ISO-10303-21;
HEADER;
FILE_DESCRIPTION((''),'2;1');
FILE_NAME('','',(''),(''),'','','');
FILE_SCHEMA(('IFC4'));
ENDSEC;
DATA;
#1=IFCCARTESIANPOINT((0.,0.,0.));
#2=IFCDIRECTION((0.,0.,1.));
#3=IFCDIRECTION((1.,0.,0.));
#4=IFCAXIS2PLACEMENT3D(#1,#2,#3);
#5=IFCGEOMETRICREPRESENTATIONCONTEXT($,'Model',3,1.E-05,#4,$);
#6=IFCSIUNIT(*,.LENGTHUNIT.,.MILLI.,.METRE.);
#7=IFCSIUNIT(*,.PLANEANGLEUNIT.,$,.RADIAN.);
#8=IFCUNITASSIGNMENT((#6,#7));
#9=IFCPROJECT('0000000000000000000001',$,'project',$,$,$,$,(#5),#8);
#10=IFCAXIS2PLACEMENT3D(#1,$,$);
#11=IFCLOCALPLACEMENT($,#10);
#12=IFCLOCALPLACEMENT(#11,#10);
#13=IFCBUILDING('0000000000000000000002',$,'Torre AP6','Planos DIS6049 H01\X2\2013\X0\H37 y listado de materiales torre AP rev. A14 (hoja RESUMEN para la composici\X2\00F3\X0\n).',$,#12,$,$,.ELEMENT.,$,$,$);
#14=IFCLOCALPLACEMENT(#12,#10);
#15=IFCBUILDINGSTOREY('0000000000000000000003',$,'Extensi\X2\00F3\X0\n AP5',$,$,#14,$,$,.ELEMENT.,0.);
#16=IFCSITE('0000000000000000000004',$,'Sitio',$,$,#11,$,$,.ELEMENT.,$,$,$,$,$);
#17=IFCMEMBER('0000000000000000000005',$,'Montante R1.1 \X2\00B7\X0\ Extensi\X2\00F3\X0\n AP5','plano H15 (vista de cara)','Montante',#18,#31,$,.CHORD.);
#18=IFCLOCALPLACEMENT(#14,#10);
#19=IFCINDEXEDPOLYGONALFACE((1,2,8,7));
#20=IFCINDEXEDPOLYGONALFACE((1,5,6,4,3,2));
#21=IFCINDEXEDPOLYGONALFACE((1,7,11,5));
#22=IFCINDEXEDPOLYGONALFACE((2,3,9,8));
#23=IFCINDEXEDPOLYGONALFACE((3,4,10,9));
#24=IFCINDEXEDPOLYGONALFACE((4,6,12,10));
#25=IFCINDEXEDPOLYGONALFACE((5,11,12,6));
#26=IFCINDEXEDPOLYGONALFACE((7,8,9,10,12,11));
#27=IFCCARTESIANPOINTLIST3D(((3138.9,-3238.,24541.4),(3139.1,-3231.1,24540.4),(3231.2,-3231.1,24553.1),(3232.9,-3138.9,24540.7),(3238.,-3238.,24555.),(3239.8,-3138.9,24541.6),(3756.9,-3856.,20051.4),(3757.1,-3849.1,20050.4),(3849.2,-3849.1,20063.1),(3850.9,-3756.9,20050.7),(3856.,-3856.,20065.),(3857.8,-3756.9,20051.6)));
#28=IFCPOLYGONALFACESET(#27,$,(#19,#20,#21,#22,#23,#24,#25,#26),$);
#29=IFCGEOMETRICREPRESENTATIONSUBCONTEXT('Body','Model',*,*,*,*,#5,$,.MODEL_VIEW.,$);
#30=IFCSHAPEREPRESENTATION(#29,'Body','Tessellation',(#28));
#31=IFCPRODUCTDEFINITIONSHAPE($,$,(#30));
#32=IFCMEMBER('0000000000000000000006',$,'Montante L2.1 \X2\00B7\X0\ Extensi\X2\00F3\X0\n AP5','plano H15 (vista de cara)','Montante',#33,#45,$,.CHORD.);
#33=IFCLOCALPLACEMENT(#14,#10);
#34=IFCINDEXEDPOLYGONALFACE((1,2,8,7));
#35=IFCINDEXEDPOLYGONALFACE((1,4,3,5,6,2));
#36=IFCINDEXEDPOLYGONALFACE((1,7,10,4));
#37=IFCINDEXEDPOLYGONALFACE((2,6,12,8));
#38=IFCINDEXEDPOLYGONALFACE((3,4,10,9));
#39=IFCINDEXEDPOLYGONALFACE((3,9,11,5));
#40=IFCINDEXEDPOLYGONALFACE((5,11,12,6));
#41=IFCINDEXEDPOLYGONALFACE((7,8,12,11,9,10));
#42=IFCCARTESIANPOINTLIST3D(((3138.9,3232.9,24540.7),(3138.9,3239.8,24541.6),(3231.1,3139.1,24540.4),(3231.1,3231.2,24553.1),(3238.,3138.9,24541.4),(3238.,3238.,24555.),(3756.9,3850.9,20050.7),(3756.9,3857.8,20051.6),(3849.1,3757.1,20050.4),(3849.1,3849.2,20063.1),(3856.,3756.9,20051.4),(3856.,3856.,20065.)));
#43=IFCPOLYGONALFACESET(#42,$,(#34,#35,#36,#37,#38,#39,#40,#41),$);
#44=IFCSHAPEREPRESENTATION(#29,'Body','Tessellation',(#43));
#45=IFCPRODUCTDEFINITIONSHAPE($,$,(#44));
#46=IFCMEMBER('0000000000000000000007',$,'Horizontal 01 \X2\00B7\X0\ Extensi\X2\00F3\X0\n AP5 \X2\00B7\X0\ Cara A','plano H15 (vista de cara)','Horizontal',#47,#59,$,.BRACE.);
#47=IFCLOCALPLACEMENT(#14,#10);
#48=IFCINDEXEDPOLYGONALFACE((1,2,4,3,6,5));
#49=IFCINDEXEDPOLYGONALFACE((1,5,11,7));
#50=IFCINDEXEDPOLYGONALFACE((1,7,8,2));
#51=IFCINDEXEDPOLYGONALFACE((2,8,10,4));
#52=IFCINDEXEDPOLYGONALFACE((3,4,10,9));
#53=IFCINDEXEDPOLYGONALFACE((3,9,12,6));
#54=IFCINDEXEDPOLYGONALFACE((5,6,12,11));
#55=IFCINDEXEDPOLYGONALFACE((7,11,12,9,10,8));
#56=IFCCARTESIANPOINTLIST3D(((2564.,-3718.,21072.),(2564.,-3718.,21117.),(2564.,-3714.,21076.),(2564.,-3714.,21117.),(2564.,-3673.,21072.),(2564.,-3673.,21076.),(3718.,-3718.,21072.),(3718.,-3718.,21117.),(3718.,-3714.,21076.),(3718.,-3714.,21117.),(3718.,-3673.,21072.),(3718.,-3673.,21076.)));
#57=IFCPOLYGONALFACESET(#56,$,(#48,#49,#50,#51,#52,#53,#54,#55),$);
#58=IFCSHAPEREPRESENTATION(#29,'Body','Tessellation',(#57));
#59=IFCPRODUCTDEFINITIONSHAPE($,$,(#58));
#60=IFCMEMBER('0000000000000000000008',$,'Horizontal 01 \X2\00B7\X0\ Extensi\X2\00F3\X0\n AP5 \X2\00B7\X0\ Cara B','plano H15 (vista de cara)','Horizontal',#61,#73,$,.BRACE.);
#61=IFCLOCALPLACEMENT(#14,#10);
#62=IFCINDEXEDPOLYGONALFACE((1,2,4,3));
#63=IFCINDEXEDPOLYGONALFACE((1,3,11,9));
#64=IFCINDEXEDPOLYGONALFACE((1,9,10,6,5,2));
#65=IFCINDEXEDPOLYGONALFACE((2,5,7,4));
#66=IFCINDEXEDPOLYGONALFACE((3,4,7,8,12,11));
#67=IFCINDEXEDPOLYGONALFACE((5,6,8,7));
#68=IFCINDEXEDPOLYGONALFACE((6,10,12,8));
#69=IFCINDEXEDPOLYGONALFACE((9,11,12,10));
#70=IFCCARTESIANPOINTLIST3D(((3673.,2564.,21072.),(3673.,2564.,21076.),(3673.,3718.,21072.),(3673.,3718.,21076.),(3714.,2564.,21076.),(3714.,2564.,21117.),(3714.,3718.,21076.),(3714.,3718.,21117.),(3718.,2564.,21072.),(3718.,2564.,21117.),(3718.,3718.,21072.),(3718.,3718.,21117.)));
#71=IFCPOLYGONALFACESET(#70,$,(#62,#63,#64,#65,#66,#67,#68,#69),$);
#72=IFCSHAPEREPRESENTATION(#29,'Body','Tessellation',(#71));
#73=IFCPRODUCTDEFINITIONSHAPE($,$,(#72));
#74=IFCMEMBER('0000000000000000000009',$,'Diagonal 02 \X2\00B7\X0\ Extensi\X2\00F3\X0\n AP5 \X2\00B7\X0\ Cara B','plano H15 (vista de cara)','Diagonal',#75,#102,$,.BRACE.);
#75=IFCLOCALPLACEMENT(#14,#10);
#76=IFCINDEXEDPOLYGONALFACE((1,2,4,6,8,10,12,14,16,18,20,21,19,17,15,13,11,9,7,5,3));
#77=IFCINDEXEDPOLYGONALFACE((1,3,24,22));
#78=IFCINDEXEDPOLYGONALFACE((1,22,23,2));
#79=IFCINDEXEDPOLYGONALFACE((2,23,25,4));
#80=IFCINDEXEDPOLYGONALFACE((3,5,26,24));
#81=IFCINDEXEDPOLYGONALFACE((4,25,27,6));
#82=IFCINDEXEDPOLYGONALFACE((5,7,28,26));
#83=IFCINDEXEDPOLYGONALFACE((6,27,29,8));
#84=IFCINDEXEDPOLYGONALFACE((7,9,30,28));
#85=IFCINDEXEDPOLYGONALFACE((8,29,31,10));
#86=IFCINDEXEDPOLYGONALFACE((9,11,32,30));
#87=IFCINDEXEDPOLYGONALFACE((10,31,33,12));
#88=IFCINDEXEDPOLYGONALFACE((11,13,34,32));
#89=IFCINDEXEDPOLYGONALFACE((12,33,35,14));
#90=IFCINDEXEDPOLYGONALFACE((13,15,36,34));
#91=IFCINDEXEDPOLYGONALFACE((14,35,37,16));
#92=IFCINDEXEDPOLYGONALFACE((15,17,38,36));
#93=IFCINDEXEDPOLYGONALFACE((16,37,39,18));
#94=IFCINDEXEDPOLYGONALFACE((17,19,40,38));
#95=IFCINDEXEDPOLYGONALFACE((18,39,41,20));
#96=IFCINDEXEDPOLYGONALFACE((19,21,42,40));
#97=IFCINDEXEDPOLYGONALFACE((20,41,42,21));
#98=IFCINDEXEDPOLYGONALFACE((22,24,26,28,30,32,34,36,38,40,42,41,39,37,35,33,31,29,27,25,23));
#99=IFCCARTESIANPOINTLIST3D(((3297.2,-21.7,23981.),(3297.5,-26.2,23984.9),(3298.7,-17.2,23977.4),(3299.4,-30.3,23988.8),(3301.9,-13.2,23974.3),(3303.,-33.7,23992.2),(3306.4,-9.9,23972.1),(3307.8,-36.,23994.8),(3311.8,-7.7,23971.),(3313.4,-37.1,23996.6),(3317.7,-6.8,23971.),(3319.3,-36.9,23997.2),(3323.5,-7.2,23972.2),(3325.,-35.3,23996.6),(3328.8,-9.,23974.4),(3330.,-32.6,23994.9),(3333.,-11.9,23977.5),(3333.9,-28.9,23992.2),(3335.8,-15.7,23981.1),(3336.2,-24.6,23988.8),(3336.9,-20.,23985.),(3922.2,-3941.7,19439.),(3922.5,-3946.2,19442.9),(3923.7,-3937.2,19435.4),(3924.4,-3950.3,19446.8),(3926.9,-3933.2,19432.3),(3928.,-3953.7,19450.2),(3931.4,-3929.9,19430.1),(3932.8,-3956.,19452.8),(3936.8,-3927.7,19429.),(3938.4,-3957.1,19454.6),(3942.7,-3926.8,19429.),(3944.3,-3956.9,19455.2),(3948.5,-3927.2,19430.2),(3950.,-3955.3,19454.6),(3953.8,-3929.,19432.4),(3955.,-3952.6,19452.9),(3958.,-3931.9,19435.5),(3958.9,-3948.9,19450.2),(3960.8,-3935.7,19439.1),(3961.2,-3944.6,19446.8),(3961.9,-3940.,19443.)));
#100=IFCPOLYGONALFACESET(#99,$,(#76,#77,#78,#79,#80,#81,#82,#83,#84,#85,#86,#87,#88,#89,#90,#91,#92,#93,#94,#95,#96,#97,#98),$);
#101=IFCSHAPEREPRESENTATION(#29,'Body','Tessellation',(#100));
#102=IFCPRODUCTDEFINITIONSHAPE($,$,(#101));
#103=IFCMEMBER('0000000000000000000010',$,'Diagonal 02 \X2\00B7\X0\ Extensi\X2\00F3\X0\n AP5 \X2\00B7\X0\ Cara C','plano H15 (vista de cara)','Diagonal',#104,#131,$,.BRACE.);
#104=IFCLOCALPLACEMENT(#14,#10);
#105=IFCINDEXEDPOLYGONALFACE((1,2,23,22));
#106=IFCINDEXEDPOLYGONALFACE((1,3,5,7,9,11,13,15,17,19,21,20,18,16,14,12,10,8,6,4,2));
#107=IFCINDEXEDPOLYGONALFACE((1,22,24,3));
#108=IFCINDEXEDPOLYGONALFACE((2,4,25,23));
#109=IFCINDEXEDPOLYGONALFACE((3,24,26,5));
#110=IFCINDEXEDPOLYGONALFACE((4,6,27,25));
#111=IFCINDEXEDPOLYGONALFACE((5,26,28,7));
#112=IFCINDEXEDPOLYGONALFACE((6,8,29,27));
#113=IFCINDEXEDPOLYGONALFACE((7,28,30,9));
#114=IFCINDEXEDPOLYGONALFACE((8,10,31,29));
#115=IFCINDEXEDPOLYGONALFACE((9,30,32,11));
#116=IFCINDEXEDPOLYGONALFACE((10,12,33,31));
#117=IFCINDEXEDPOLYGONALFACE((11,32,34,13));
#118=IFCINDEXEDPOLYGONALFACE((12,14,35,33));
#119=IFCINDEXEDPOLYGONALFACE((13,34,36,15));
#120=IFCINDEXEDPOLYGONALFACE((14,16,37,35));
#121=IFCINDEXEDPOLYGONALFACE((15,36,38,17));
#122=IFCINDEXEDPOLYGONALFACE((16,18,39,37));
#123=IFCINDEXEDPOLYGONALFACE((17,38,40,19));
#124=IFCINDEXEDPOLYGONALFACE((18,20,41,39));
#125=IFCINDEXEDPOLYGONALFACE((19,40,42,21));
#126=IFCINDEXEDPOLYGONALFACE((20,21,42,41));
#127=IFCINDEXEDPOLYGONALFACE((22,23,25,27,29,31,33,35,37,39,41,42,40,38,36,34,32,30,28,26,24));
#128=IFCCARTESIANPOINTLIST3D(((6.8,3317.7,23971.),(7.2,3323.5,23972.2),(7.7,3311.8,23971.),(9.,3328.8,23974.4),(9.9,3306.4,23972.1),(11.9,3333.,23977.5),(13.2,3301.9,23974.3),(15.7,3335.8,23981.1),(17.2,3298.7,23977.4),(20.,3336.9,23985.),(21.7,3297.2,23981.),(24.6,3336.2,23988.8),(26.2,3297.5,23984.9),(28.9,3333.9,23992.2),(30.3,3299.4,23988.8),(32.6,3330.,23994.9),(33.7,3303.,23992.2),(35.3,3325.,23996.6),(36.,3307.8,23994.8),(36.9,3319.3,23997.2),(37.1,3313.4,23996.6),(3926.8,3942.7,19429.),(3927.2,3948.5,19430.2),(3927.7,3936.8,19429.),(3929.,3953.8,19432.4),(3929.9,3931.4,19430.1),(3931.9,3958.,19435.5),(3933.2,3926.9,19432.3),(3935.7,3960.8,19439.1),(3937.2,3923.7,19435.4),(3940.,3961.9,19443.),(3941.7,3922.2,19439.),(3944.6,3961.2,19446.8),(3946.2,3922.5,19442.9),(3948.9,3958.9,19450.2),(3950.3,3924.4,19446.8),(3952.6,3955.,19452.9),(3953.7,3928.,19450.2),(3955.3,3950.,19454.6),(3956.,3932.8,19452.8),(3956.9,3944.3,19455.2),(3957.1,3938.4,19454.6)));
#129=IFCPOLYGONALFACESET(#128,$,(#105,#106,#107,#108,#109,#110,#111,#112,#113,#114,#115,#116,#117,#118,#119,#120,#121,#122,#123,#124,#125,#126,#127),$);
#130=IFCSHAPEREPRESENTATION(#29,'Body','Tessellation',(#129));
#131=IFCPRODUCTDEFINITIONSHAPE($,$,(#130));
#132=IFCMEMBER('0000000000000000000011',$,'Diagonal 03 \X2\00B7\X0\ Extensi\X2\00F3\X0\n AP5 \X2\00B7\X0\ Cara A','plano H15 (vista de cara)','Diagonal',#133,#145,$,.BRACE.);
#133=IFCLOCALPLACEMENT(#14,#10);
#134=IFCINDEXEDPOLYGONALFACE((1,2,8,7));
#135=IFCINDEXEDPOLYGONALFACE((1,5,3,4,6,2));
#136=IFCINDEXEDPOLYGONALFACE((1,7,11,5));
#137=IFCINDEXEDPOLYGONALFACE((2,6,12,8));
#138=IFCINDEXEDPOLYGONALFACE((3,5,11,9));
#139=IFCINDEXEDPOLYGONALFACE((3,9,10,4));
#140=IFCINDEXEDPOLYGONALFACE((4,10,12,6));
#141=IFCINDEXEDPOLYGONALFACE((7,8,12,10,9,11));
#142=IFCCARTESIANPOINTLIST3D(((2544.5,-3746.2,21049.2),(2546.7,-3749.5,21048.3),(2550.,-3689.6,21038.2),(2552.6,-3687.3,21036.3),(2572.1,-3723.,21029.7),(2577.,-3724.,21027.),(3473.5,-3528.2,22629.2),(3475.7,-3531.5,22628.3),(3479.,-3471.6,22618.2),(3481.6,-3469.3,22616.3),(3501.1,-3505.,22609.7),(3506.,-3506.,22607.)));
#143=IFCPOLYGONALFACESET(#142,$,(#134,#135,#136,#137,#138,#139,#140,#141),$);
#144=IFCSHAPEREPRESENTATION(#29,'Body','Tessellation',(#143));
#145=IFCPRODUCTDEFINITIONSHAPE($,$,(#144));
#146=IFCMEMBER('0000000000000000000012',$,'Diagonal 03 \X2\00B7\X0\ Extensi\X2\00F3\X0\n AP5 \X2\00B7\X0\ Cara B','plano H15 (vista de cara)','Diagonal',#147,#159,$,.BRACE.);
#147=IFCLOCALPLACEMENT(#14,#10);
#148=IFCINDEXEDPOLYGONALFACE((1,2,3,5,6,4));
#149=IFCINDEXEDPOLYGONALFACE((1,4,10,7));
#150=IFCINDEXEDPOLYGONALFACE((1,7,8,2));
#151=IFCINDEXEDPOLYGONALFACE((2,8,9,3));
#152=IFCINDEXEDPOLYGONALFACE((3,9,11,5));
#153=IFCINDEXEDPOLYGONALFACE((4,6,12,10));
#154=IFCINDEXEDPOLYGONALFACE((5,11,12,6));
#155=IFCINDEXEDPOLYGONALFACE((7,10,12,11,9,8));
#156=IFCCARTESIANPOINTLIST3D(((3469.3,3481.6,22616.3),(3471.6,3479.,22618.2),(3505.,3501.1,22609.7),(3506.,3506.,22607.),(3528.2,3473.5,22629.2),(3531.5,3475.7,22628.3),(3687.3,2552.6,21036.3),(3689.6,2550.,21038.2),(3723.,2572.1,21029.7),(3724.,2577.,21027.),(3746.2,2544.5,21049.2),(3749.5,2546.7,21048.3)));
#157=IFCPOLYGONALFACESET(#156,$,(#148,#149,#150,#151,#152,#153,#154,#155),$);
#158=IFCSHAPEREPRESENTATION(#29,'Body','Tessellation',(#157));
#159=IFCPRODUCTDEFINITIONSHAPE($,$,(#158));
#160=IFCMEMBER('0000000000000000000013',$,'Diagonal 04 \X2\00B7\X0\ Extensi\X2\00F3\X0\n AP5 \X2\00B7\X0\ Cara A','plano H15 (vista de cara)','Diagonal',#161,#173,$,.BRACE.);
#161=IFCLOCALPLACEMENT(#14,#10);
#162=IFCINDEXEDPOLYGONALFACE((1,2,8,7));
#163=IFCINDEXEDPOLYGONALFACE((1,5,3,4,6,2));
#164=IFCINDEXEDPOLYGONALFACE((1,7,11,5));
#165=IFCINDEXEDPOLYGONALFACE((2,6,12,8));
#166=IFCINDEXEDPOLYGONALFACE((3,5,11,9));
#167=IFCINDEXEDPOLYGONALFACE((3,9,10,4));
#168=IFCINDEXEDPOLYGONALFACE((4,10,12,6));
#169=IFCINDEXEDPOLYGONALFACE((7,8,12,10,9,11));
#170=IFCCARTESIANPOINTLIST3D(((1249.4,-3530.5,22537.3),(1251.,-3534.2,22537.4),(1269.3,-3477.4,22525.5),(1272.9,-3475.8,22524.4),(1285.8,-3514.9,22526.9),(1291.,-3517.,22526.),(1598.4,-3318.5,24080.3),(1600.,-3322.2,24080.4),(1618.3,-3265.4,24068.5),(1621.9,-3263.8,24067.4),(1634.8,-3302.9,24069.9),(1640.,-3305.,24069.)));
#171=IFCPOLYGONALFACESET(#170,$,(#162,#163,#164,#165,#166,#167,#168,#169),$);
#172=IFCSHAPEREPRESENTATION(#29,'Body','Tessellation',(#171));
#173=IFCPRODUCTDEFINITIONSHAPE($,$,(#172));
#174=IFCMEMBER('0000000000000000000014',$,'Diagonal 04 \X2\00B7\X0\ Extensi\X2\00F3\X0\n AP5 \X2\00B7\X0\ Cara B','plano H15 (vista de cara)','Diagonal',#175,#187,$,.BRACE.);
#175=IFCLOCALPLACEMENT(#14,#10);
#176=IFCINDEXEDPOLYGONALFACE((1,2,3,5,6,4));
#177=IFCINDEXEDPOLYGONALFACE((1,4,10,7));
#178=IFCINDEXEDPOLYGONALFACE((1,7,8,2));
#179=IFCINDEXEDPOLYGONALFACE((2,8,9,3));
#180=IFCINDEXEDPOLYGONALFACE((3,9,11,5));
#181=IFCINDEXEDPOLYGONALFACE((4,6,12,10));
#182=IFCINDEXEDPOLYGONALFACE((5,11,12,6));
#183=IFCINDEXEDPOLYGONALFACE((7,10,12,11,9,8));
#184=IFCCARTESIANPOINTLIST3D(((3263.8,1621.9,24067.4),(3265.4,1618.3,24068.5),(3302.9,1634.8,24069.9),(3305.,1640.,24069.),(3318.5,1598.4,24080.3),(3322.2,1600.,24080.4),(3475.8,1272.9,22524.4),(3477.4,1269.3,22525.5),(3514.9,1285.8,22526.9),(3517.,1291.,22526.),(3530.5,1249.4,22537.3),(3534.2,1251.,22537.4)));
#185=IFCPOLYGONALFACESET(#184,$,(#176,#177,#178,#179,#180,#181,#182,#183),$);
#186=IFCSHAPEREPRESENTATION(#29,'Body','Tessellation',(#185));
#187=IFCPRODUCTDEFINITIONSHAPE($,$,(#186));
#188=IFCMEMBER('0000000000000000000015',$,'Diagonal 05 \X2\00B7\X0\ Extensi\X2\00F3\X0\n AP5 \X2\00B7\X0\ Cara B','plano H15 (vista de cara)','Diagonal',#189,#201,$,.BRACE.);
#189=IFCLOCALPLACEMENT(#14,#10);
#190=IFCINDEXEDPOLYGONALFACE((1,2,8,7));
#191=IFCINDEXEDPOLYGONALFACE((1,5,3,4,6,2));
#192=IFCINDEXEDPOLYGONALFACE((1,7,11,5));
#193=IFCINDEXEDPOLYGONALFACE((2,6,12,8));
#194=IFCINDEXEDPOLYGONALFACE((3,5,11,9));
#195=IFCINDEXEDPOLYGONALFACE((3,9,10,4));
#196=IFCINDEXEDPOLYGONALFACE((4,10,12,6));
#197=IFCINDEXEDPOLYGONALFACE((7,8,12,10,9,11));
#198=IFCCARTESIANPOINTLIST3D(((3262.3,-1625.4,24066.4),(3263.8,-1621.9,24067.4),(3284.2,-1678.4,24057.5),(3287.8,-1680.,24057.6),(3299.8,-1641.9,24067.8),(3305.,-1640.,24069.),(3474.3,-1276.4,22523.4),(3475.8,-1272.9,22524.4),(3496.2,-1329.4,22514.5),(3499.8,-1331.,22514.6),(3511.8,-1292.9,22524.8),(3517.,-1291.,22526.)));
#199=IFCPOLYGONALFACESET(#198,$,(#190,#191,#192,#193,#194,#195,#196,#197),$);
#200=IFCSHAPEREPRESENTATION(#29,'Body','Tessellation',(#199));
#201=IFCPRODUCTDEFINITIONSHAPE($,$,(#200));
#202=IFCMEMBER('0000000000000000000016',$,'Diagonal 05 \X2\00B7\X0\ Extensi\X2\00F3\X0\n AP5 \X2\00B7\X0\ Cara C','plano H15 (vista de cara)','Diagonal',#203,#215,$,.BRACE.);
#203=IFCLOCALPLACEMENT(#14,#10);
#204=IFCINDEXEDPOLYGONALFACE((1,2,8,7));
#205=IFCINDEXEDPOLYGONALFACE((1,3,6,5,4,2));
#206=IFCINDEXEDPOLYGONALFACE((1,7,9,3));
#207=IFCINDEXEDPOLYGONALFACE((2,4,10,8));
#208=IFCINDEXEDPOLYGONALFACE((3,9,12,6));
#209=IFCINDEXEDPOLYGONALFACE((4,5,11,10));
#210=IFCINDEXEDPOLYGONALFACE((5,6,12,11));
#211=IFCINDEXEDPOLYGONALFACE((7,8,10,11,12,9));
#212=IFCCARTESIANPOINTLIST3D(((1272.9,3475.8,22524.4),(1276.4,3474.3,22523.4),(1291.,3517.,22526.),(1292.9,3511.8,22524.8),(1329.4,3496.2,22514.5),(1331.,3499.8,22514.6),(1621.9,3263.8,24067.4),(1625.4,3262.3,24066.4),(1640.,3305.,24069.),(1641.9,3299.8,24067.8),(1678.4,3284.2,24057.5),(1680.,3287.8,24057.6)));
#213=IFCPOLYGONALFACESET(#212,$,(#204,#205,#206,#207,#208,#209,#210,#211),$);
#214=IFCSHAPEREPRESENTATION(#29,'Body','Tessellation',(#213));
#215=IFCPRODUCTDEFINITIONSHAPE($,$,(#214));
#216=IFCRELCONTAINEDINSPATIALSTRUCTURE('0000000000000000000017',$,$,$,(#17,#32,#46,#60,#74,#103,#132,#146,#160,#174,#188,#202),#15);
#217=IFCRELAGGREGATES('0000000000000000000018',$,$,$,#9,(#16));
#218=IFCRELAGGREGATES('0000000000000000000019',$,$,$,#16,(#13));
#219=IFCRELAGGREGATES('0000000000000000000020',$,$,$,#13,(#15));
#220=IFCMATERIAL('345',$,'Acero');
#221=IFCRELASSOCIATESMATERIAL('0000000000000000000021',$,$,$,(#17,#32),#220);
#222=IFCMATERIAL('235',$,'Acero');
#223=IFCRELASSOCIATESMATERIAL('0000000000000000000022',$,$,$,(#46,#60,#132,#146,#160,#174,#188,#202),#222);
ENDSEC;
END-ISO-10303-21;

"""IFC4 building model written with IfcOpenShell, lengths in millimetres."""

from ifc_helpers import new_model, si_unit, frame, frame_2d, origin, origin_with_axes, place, context, subcontext, project, spatial, circle, l_section, extrude, material, element, save


model = new_model("IFC4")

# Units and contexts
model_context = context("Model", 3, precision=1e-05, world=origin_with_axes())
body_context = subcontext(model_context, "Body", "Model", "MODEL_VIEW")
ifc_project = project(units=[si_unit("LENGTHUNIT", "METRE", prefix="MILLI"), si_unit("PLANEANGLEUNIT", "RADIAN")], contexts=[model_context])

# Site, building, storey
site_placement = place(None, origin())
site = spatial("IfcSite", under=ifc_project, at=site_placement, Name="Sitio", CompositionType="ELEMENT")
building_placement = place(site_placement, origin())
building = spatial("IfcBuilding", under=site, at=building_placement, Name="Torre AP6", Description="Planos DIS6049 H01–H37 y listado de materiales torre AP rev. A14 (hoja RESUMEN para la composición).", CompositionType="ELEMENT")
storey_placement = place(building_placement, origin())
storey = spatial("IfcBuildingStorey", under=building, at=storey_placement, Name="Extensión AP5", CompositionType="ELEMENT", Elevation=0.0)

# Members
ifc_material_1 = material(Name="345", Category="Acero")
for number, where, z_axis, x_axis, name in (
    (1, (3856.0, -3856.0, 20065.0), (-0.135104, 0.135104, 0.981577), (0.018422, 0.990831, -0.133842), "Montante R1.1 · Extensión AP5"),
    (2, (3856.0, 3856.0, 20065.0), (-0.135104, -0.135104, 0.981577), (-0.990831, 0.018422, -0.133842), "Montante L2.1 · Extensión AP5"),
):
    element("IfcMember", number, at=place(storey_placement, frame(where, z_axis=z_axis, x_axis=x_axis)), inside=storey, material=ifc_material_1, Name=name, Description="plano H15 (vista de cara)", ObjectType="Montante", PredefinedType="CHORD", context=body_context, shape_type="SweptSolid", body=[
        extrude(l_section(Depth=100.0, Width=100.0, Thickness=7.0, at=frame_2d((50.0, 50.0))), None, (0.0, 0.0, 1.0), 4574.3),
    ])
ifc_material_2 = material(Name="235", Category="Acero")
for number, where, z_axis, x_axis, name in (
    (3, (2564.0, -3718.0, 21072.0), (1.0, 0.0, 0.0), (0.0, 1.0, 0.0), "Horizontal 01 · Extensión AP5 · Cara A"),
    (4, (3718.0, 2564.0, 21072.0), (0.0, 1.0, 0.0), (-1.0, 0.0, 0.0), "Horizontal 01 · Extensión AP5 · Cara B"),
):
    element("IfcMember", number, at=place(storey_placement, frame(where, z_axis=z_axis, x_axis=x_axis)), inside=storey, material=ifc_material_2, Name=name, Description="plano H15 (vista de cara)", ObjectType="Horizontal", PredefinedType="BRACE", context=body_context, shape_type="SweptSolid", body=[
        extrude(l_section(Depth=45.0, Width=45.0, Thickness=4.0, at=frame_2d((22.5, 22.5))), None, (0.0, 0.0, 1.0), 1154.0),
    ])
for number, where, z_axis, x_axis, name in (
    (5, (3942.0, -3942.0, 19442.0), (-0.103612, 0.649852, 0.752966), (-0.913165, 0.237889, -0.330967), "Diagonal 02 · Extensión AP5 · Cara B"),
    (6, (3942.0, 3942.0, 19442.0), (-0.649852, -0.103612, 0.752966), (-0.237889, -0.913165, -0.330967), "Diagonal 02 · Extensión AP5 · Cara C"),
):
    element("IfcMember", number, at=place(storey_placement, frame(where, z_axis=z_axis, x_axis=x_axis)), inside=storey, Name=name, Description="plano H15 (vista de cara)", ObjectType="Diagonal", PredefinedType="BRACE", context=body_context, shape_type="SweptSolid", body=[
        extrude(circle(Radius=20.0), None, (0.0, 0.0, 1.0), 6032.1),
    ])
for number, where, z_axis, x_axis, name in (
    (7, (2577.0, -3724.0, 21027.0), (0.503306, 0.118106, 0.855999), (-0.541181, 0.815359, 0.205702), "Diagonal 03 · Extensión AP5 · Cara A"),
    (8, (3724.0, 2577.0, 21027.0), (-0.118106, 0.503306, 0.855999), (-0.815359, -0.541181, 0.205702), "Diagonal 03 · Extensión AP5 · Cara B"),
):
    element("IfcMember", number, at=place(storey_placement, frame(where, z_axis=z_axis, x_axis=x_axis)), inside=storey, material=ifc_material_2, Name=name, Description="plano H15 (vista de cara)", ObjectType="Diagonal", PredefinedType="BRACE", context=body_context, shape_type="SweptSolid", body=[
        extrude(l_section(Depth=45.0, Width=45.0, Thickness=4.0, at=frame_2d((22.5, 22.5))), None, (0.0, 0.0, 1.0), 1845.8),
    ])
for number, where, z_axis, x_axis, name in (
    (9, (1291.0, -3517.0, 22526.0), (0.218655, 0.132822, 0.96672), (-0.402816, 0.914628, -0.034555), "Diagonal 04 · Extensión AP5 · Cara A"),
    (10, (3517.0, 1291.0, 22526.0), (-0.132822, 0.218655, 0.96672), (-0.914628, -0.402816, -0.034555), "Diagonal 04 · Extensión AP5 · Cara B"),
    (11, (3517.0, -1291.0, 22526.0), (-0.132822, -0.218655, 0.96672), (-0.914628, 0.402816, -0.034555), "Diagonal 05 · Extensión AP5 · Cara B"),
    (12, (1291.0, 3517.0, 22526.0), (0.218655, -0.132822, 0.96672), (-0.402816, -0.914628, -0.034555), "Diagonal 05 · Extensión AP5 · Cara C"),
):
    element("IfcMember", number, at=place(storey_placement, frame(where, z_axis=z_axis, x_axis=x_axis)), inside=storey, material=ifc_material_2, Name=name, Description="plano H15 (vista de cara)", ObjectType="Diagonal", PredefinedType="BRACE", context=body_context, shape_type="SweptSolid", body=[
        extrude(l_section(Depth=45.0, Width=45.0, Thickness=4.0, at=frame_2d((22.5, 22.5))), None, (0.0, 0.0, 1.0), 1596.1),
    ])

save(model, "model.ifc")
